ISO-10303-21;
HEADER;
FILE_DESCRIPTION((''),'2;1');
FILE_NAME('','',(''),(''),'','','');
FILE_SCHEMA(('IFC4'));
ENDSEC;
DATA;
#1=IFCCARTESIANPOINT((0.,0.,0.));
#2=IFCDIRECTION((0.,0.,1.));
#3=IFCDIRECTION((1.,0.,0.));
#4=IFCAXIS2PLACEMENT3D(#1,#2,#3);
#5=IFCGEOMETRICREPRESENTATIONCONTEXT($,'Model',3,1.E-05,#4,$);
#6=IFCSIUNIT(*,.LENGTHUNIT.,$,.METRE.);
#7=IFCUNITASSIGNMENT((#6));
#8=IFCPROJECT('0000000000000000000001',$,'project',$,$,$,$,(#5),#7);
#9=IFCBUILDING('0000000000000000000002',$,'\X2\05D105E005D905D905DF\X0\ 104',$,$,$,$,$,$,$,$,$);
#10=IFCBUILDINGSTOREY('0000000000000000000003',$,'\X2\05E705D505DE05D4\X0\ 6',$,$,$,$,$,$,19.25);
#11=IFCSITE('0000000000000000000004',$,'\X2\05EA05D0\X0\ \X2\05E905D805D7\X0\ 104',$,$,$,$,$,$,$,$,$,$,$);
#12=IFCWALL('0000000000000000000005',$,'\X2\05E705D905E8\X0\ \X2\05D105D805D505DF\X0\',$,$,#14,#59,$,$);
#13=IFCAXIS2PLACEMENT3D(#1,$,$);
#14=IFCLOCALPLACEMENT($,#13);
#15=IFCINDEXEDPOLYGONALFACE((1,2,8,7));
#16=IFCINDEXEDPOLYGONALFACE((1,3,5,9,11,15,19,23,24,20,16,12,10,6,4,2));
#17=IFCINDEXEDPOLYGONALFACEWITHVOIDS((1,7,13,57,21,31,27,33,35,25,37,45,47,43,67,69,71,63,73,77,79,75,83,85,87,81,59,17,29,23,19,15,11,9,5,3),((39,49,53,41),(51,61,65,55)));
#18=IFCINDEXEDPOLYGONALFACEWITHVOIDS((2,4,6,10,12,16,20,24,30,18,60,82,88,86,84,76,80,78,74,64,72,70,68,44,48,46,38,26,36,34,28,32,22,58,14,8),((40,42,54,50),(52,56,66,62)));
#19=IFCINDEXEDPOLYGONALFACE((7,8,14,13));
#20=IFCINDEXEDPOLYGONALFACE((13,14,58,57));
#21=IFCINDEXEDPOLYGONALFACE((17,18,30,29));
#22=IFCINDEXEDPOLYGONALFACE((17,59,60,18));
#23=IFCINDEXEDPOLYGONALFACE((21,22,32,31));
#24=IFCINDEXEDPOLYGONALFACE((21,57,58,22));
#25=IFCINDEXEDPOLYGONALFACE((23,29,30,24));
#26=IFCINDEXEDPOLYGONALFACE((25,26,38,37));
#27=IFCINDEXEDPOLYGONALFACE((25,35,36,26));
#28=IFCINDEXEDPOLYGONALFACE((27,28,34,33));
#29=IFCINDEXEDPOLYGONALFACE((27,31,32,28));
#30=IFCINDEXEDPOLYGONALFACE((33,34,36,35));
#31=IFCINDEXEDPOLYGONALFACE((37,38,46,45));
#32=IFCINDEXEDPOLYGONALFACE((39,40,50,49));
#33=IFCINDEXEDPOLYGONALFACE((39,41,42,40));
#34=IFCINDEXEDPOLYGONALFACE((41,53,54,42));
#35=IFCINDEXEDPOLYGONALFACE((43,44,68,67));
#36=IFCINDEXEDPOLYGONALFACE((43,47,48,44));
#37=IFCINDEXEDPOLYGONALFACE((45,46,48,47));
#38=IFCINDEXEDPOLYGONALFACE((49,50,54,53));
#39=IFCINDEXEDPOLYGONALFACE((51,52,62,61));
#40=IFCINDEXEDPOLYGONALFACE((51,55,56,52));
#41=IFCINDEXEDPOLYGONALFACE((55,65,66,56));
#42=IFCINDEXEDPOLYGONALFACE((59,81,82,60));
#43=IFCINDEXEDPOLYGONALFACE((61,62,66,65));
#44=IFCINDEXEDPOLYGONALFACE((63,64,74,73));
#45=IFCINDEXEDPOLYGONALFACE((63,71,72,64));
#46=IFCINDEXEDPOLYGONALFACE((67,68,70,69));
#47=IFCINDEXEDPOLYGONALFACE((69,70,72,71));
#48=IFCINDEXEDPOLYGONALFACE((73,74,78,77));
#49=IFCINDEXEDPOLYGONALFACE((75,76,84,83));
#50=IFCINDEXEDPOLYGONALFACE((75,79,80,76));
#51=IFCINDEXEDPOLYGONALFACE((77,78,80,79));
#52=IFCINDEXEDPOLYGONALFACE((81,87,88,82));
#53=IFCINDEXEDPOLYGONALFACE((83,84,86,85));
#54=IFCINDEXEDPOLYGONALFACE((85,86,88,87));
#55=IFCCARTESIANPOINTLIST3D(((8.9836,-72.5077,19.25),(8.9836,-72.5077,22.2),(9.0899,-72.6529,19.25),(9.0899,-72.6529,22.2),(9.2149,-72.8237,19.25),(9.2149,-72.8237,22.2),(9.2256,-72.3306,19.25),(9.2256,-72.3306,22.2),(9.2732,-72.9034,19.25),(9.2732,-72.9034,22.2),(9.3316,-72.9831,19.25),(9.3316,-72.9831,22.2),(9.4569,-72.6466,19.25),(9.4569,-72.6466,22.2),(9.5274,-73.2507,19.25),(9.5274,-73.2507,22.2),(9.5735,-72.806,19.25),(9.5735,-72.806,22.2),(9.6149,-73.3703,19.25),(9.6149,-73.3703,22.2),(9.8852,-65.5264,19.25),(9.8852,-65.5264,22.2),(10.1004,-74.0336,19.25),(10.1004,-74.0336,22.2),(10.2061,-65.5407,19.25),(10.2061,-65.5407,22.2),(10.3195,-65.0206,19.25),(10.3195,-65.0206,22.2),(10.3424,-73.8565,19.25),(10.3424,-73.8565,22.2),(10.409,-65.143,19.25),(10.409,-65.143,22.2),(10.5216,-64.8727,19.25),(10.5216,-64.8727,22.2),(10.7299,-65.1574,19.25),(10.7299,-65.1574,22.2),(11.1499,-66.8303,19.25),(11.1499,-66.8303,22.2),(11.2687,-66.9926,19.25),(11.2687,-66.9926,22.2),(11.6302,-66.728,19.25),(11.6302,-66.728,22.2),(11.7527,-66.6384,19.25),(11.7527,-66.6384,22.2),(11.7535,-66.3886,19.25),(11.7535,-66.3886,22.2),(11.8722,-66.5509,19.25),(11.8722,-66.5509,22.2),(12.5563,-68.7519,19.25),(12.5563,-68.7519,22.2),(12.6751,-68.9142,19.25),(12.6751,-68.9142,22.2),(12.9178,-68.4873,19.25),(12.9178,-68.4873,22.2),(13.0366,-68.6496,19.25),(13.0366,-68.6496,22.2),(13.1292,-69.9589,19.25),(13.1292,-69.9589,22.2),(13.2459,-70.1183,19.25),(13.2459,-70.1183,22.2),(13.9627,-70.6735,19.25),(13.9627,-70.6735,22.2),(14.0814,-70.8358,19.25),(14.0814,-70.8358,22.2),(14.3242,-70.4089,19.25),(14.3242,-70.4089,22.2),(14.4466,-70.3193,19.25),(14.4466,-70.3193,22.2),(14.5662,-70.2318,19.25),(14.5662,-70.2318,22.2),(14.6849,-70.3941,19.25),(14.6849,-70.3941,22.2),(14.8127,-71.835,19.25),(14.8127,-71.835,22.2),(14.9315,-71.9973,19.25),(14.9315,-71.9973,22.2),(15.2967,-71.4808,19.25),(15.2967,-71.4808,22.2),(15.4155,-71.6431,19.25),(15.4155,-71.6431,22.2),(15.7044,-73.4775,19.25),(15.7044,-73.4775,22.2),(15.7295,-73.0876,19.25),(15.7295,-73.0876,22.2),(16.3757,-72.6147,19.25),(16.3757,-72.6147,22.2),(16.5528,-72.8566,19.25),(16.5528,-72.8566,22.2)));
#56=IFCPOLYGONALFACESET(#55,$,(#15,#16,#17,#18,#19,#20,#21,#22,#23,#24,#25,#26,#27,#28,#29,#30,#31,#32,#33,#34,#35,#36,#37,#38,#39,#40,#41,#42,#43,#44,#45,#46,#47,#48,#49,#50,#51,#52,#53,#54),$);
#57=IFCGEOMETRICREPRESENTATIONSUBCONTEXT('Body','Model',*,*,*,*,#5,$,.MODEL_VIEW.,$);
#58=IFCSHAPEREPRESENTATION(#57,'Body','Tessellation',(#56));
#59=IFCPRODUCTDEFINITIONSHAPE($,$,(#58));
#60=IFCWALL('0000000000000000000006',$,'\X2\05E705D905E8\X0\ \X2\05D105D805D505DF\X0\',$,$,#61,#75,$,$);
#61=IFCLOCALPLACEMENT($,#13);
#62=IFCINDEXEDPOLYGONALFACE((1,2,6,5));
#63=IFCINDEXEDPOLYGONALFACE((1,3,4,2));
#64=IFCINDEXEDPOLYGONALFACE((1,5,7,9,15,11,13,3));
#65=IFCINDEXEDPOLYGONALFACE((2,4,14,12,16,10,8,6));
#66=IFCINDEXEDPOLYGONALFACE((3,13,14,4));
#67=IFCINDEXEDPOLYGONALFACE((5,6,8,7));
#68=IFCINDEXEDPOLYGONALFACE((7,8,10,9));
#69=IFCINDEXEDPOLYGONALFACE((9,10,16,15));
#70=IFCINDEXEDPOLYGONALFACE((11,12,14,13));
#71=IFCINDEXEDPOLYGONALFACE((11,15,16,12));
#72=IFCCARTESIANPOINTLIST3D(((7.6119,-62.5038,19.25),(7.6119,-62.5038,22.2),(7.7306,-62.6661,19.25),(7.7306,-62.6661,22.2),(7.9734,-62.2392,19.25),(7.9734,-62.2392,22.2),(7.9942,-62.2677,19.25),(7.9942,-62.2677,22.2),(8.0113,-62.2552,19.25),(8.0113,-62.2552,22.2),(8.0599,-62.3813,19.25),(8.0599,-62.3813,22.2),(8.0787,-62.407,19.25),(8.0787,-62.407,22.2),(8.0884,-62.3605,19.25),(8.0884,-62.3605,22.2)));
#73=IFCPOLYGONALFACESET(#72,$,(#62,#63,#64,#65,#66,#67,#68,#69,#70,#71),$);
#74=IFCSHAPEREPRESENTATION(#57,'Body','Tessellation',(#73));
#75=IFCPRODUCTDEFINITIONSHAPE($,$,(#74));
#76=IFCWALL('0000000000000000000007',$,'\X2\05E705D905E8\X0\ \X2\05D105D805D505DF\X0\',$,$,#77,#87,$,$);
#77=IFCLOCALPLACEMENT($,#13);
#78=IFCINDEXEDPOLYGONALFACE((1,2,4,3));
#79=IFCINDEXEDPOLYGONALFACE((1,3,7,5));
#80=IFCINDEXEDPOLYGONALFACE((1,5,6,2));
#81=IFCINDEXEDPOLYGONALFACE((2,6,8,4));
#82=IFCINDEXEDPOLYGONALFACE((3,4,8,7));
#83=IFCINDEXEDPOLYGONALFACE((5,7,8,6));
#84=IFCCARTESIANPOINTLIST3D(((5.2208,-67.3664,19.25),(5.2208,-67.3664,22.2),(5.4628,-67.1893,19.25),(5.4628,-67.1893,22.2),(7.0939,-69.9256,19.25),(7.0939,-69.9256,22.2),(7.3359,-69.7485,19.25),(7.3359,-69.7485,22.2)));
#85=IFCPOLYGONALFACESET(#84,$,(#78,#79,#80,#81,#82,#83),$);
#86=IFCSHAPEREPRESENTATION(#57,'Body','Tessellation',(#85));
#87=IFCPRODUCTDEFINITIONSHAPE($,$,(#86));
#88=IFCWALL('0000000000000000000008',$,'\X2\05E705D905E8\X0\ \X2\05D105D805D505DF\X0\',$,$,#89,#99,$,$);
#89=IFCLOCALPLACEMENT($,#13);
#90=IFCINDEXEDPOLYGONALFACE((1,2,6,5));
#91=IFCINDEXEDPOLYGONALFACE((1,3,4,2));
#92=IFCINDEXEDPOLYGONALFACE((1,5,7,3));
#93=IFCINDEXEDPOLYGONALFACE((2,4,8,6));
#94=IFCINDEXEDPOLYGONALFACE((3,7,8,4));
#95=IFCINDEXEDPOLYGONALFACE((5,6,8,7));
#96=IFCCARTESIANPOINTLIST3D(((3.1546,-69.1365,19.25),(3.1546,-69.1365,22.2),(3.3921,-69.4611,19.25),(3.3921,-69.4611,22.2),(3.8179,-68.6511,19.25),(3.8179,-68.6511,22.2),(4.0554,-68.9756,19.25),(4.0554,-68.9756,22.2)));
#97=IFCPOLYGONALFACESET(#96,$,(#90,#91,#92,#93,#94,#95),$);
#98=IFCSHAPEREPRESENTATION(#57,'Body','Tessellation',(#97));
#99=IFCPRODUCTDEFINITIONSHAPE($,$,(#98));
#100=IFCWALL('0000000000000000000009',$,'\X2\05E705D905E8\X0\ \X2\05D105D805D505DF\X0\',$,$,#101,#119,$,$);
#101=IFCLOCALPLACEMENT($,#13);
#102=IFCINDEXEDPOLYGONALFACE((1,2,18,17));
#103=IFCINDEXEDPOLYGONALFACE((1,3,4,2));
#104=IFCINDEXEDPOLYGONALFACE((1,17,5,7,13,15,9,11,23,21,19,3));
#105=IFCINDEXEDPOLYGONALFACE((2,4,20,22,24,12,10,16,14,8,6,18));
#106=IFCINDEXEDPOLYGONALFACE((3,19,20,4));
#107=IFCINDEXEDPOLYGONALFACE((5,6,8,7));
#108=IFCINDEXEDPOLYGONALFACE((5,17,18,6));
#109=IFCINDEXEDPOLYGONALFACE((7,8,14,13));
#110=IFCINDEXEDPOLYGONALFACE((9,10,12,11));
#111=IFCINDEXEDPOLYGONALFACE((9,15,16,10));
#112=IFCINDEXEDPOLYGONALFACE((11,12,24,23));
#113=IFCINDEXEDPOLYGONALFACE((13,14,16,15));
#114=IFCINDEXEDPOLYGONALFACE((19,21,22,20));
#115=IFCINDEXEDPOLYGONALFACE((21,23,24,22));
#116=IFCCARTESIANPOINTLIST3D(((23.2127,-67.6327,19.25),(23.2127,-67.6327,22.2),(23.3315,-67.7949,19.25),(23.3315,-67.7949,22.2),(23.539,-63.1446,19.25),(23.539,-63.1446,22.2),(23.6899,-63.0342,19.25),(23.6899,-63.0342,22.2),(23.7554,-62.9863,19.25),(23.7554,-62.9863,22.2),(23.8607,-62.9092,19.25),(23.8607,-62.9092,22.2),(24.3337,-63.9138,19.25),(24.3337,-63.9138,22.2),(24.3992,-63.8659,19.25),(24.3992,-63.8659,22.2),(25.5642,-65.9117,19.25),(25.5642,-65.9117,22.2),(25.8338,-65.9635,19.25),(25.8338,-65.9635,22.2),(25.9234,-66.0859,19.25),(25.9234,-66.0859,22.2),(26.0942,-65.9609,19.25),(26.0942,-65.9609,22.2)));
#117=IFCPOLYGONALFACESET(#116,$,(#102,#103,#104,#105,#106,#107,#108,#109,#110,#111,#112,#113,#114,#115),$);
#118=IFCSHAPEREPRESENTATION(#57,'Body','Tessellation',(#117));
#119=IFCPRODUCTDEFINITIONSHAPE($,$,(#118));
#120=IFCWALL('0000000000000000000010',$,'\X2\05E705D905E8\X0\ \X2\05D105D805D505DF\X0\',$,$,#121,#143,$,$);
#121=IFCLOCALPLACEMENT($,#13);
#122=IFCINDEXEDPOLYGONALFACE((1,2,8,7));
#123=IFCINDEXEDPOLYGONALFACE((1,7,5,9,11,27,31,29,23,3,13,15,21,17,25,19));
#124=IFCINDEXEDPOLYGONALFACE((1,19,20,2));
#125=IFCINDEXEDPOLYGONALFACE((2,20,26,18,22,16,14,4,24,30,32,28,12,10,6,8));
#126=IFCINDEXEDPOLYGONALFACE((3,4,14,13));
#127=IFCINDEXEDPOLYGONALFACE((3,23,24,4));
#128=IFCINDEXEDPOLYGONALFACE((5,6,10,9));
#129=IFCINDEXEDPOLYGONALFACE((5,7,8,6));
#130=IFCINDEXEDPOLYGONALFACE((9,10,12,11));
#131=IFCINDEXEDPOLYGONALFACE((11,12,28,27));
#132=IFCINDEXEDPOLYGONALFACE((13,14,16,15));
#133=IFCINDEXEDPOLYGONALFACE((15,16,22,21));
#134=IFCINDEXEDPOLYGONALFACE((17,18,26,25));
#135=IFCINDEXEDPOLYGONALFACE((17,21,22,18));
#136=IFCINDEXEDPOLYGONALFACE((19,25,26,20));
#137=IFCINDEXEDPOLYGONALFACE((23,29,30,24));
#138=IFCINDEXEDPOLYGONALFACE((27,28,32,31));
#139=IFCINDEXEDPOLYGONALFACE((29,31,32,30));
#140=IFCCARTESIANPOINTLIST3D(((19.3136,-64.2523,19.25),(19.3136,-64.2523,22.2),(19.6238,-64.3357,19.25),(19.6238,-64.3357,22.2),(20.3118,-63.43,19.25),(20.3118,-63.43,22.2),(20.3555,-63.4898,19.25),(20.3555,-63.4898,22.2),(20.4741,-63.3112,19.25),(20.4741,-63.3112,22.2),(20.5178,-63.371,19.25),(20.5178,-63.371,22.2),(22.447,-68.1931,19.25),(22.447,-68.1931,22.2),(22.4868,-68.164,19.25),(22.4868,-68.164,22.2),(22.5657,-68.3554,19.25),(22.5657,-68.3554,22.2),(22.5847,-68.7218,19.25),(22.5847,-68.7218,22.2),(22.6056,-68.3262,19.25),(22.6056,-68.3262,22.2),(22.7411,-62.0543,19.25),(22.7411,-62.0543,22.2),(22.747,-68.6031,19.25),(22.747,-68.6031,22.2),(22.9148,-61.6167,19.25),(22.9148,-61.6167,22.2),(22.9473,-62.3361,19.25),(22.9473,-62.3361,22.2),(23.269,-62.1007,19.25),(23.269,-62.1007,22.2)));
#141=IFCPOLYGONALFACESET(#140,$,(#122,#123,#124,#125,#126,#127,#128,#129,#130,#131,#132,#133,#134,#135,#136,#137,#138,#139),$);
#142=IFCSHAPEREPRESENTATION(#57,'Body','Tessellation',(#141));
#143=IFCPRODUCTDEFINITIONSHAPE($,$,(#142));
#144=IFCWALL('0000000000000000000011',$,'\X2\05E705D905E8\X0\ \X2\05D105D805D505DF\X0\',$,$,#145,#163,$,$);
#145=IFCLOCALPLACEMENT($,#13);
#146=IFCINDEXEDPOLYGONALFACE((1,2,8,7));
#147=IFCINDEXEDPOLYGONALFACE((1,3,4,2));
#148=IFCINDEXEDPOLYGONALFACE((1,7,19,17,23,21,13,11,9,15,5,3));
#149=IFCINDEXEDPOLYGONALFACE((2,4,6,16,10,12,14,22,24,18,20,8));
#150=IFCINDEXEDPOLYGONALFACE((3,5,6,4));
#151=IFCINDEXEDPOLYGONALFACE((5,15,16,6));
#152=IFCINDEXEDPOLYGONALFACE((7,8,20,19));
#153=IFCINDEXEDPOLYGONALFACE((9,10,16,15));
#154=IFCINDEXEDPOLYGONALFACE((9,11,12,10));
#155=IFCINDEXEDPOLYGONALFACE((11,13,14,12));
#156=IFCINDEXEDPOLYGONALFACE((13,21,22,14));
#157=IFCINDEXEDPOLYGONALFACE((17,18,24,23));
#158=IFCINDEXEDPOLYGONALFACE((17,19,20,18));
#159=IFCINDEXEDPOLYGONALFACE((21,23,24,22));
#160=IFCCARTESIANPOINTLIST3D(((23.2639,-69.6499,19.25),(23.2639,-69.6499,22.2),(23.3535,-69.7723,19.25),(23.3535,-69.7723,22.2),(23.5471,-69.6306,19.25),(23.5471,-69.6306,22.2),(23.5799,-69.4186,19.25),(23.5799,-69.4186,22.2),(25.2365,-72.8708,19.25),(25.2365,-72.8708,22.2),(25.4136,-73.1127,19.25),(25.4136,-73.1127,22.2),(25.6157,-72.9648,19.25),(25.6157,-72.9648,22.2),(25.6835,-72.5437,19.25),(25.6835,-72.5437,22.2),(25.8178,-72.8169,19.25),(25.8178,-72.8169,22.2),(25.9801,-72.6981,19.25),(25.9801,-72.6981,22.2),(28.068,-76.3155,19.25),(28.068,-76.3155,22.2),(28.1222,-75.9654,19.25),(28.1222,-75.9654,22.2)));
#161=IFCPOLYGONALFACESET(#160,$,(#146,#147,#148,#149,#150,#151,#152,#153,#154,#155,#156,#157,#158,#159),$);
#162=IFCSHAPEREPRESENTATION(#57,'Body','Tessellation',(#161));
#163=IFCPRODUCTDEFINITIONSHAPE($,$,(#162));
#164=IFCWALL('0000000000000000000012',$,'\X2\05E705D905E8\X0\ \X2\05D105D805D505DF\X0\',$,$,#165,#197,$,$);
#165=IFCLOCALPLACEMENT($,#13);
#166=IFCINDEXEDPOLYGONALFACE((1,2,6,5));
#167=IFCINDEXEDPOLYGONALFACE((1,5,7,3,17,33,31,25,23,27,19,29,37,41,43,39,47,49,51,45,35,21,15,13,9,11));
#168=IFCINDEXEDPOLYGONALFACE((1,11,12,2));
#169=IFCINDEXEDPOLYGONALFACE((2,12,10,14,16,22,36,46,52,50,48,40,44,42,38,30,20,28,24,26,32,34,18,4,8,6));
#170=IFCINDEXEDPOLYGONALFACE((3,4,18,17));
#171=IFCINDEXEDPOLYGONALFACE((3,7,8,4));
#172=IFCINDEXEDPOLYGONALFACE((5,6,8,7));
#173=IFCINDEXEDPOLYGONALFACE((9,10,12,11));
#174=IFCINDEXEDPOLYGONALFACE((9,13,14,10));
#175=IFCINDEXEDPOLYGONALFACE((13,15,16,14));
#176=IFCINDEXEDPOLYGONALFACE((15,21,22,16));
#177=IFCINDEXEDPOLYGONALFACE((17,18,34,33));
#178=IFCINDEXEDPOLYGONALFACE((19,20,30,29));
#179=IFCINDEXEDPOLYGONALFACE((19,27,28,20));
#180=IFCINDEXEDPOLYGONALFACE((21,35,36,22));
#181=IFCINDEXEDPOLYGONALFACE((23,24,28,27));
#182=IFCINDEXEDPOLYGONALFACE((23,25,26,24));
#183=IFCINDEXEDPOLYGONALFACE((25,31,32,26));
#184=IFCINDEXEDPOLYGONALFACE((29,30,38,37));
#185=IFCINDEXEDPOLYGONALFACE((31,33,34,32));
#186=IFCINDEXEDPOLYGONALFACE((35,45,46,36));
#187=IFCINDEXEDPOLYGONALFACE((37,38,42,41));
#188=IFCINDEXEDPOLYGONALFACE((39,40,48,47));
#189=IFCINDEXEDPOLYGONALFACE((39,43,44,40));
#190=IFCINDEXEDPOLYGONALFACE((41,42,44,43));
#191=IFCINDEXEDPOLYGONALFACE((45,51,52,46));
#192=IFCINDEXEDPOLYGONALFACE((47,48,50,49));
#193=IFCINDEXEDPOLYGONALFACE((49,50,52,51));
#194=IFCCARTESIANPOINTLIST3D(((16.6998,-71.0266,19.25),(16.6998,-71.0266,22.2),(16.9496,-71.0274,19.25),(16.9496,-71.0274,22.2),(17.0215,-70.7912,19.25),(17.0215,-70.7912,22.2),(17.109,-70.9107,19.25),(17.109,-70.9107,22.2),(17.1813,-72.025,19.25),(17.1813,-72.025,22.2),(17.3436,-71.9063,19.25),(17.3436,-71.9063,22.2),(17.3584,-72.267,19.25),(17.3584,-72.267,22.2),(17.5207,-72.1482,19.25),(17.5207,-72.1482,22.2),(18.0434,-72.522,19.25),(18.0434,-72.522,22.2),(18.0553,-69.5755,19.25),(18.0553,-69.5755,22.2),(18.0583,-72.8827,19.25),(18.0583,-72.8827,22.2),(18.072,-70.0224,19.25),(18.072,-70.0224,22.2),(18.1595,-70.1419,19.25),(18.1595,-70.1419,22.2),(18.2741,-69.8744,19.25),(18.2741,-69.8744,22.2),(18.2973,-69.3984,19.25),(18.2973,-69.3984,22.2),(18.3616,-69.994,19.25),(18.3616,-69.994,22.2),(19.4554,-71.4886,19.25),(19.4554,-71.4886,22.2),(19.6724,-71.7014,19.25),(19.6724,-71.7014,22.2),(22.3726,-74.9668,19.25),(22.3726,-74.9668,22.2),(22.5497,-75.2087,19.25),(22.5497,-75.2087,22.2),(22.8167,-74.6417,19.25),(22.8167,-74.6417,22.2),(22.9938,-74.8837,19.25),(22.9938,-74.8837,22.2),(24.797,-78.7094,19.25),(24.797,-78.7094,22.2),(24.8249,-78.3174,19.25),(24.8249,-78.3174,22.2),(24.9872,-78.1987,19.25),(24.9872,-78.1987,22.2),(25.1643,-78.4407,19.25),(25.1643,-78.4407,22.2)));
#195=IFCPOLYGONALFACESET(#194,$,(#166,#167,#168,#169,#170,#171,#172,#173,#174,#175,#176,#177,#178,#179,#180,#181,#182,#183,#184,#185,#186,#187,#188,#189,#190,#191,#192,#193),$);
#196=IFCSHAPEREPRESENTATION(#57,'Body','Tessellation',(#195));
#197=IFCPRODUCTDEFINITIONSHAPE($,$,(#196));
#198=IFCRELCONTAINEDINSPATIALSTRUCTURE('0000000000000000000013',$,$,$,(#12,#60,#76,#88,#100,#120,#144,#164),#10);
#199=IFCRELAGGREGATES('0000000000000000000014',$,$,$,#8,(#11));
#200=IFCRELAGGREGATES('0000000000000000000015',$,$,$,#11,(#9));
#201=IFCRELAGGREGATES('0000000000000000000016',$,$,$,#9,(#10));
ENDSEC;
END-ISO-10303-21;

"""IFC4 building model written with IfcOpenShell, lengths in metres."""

from ifc_helpers import new_model, si_unit, frame, origin_with_axes, context, subcontext, project, spatial, polyline, outline, extrude, element, save


model = new_model("IFC4")

# Units and contexts
model_context = context("Model", 3, precision=1e-05, world=origin_with_axes())
body_context = subcontext(model_context, "Body", "Model", "MODEL_VIEW")
ifc_project = project(units=[si_unit("LENGTHUNIT", "METRE")], contexts=[model_context])

# Site, building, storey
site = spatial("IfcSite", under=ifc_project, Name="תא שטח 104")
building = spatial("IfcBuilding", under=site, Name="בניין 104")
storey = spatial("IfcBuildingStorey", under=building, Name="קומה 6", Elevation=19.25)

# Walls
element("IfcWall", 1, inside=storey, Name="קיר בטון", context=body_context, shape_type="SweptSolid", body=[
    extrude(outline(polyline([(10.409, -65.143), (9.8852, -65.5264), (13.1292, -69.9589), (9.4569, -72.6466), (9.2256, -72.3306), (8.9836, -72.5077), (9.0899, -72.6529), (9.2149, -72.8237), (9.2732, -72.9034), (9.3316, -72.9831), (9.5274, -73.2507), (9.6149, -73.3703), (10.1004, -74.0336), (10.3424, -73.8565), (9.5735, -72.806), (13.2459, -70.1183), (15.7044, -73.4775), (16.5528, -72.8566), (16.3757, -72.6147), (15.7295, -73.0876), (14.9315, -71.9973), (15.4155, -71.6431), (15.2967, -71.4808), (14.8127, -71.835), (14.0814, -70.8358), (14.6849, -70.3941), (14.5662, -70.2318), (14.4466, -70.3193), (11.7527, -66.6384), (11.8722, -66.5509), (11.7535, -66.3886), (11.1499, -66.8303), (10.2061, -65.5407), (10.7299, -65.1574), (10.5216, -64.8727), (10.3195, -65.0206), (10.409, -65.143)]), holes=[polyline([(11.6302, -66.728), (12.9178, -68.4873), (12.5563, -68.7519), (11.2687, -66.9926), (11.6302, -66.728)]), polyline([(13.0366, -68.6496), (14.3242, -70.4089), (13.9627, -70.6735), (12.6751, -68.9142), (13.0366, -68.6496)])]), frame((0.0, 0.0, 19.25)), (0.0, 0.0, 1.0), 2.95),
])
element("IfcWall", 2, inside=storey, Name="קיר בטון", context=body_context, shape_type="SweptSolid", body=[
    extrude(outline(polyline([(7.6119, -62.5038), (7.7306, -62.6661), (8.0787, -62.407), (8.0599, -62.3813), (8.0884, -62.3605), (8.0113, -62.2552), (7.9942, -62.2677), (7.9734, -62.2392), (7.6119, -62.5038)])), frame((0.0, 0.0, 19.25)), (0.0, 0.0, 1.0), 2.95),
])
element("IfcWall", 3, inside=storey, Name="קיר בטון", context=body_context, shape_type="SweptSolid", body=[
    extrude(outline(polyline([(5.4628, -67.1893), (5.2208, -67.3664), (7.0939, -69.9256), (7.3359, -69.7485), (5.4628, -67.1893)])), frame((0.0, 0.0, 19.25)), (0.0, 0.0, 1.0), 2.95),
])
element("IfcWall", 4, inside=storey, Name="קיר בטון", context=body_context, shape_type="SweptSolid", body=[
    extrude(outline(polyline([(4.0554, -68.9756), (3.8179, -68.6511), (3.1546, -69.1365), (3.3921, -69.4611), (4.0554, -68.9756)])), frame((0.0, 0.0, 19.25)), (0.0, 0.0, 1.0), 2.95),
])
element("IfcWall", 5, inside=storey, Name="קיר בטון", context=body_context, shape_type="SweptSolid", body=[
    extrude(outline(polyline([(24.3992, -63.8659), (24.3337, -63.9138), (23.6899, -63.0342), (23.539, -63.1446), (25.5642, -65.9117), (23.2127, -67.6327), (23.3315, -67.7949), (25.8338, -65.9635), (25.9234, -66.0859), (26.0942, -65.9609), (23.8607, -62.9092), (23.7554, -62.9863), (24.3992, -63.8659)])), frame((0.0, 0.0, 19.25)), (0.0, 0.0, 1.0), 2.95),
])
element("IfcWall", 6, inside=storey, Name="קיר בטון", context=body_context, shape_type="SweptSolid", body=[
    extrude(outline(polyline([(22.9148, -61.6167), (20.5178, -63.371), (20.4741, -63.3112), (20.3118, -63.43), (20.3555, -63.4898), (19.3136, -64.2523), (22.5847, -68.7218), (22.747, -68.6031), (22.5657, -68.3554), (22.6056, -68.3262), (22.4868, -68.164), (22.447, -68.1931), (19.6238, -64.3357), (22.7411, -62.0543), (22.9473, -62.3361), (23.269, -62.1007), (22.9148, -61.6167)])), frame((0.0, 0.0, 19.25)), (0.0, 0.0, 1.0), 2.95),
])
element("IfcWall", 7, inside=storey, Name="קיר בטון", context=body_context, shape_type="SweptSolid", body=[
    extrude(outline(polyline([(23.2639, -69.6499), (23.3535, -69.7723), (23.5471, -69.6306), (25.6835, -72.5437), (25.2365, -72.8708), (25.4136, -73.1127), (25.6157, -72.9648), (28.068, -76.3155), (28.1222, -75.9654), (25.8178, -72.8169), (25.9801, -72.6981), (23.5799, -69.4186), (23.2639, -69.6499)])), frame((0.0, 0.0, 19.25)), (0.0, 0.0, 1.0), 2.95),
])
element("IfcWall", 8, inside=storey, Name="קיר בטון", context=body_context, shape_type="SweptSolid", body=[
    extrude(outline(polyline([(18.3616, -69.994), (19.4554, -71.4886), (18.0434, -72.522), (16.9496, -71.0274), (17.109, -70.9107), (17.0215, -70.7912), (16.6998, -71.0266), (17.3436, -71.9063), (17.1813, -72.025), (17.3584, -72.267), (17.5207, -72.1482), (18.0583, -72.8827), (19.6724, -71.7014), (24.797, -78.7094), (25.1643, -78.4407), (24.9872, -78.1987), (24.8249, -78.3174), (22.5497, -75.2087), (22.9938, -74.8837), (22.8167, -74.6417), (22.3726, -74.9668), (18.2973, -69.3984), (18.0553, -69.5755), (18.2741, -69.8744), (18.072, -70.0224), (18.1595, -70.1419), (18.3616, -69.994)])), frame((0.0, 0.0, 19.25)), (0.0, 0.0, 1.0), 2.95),
])

save(model, "model.ifc")
